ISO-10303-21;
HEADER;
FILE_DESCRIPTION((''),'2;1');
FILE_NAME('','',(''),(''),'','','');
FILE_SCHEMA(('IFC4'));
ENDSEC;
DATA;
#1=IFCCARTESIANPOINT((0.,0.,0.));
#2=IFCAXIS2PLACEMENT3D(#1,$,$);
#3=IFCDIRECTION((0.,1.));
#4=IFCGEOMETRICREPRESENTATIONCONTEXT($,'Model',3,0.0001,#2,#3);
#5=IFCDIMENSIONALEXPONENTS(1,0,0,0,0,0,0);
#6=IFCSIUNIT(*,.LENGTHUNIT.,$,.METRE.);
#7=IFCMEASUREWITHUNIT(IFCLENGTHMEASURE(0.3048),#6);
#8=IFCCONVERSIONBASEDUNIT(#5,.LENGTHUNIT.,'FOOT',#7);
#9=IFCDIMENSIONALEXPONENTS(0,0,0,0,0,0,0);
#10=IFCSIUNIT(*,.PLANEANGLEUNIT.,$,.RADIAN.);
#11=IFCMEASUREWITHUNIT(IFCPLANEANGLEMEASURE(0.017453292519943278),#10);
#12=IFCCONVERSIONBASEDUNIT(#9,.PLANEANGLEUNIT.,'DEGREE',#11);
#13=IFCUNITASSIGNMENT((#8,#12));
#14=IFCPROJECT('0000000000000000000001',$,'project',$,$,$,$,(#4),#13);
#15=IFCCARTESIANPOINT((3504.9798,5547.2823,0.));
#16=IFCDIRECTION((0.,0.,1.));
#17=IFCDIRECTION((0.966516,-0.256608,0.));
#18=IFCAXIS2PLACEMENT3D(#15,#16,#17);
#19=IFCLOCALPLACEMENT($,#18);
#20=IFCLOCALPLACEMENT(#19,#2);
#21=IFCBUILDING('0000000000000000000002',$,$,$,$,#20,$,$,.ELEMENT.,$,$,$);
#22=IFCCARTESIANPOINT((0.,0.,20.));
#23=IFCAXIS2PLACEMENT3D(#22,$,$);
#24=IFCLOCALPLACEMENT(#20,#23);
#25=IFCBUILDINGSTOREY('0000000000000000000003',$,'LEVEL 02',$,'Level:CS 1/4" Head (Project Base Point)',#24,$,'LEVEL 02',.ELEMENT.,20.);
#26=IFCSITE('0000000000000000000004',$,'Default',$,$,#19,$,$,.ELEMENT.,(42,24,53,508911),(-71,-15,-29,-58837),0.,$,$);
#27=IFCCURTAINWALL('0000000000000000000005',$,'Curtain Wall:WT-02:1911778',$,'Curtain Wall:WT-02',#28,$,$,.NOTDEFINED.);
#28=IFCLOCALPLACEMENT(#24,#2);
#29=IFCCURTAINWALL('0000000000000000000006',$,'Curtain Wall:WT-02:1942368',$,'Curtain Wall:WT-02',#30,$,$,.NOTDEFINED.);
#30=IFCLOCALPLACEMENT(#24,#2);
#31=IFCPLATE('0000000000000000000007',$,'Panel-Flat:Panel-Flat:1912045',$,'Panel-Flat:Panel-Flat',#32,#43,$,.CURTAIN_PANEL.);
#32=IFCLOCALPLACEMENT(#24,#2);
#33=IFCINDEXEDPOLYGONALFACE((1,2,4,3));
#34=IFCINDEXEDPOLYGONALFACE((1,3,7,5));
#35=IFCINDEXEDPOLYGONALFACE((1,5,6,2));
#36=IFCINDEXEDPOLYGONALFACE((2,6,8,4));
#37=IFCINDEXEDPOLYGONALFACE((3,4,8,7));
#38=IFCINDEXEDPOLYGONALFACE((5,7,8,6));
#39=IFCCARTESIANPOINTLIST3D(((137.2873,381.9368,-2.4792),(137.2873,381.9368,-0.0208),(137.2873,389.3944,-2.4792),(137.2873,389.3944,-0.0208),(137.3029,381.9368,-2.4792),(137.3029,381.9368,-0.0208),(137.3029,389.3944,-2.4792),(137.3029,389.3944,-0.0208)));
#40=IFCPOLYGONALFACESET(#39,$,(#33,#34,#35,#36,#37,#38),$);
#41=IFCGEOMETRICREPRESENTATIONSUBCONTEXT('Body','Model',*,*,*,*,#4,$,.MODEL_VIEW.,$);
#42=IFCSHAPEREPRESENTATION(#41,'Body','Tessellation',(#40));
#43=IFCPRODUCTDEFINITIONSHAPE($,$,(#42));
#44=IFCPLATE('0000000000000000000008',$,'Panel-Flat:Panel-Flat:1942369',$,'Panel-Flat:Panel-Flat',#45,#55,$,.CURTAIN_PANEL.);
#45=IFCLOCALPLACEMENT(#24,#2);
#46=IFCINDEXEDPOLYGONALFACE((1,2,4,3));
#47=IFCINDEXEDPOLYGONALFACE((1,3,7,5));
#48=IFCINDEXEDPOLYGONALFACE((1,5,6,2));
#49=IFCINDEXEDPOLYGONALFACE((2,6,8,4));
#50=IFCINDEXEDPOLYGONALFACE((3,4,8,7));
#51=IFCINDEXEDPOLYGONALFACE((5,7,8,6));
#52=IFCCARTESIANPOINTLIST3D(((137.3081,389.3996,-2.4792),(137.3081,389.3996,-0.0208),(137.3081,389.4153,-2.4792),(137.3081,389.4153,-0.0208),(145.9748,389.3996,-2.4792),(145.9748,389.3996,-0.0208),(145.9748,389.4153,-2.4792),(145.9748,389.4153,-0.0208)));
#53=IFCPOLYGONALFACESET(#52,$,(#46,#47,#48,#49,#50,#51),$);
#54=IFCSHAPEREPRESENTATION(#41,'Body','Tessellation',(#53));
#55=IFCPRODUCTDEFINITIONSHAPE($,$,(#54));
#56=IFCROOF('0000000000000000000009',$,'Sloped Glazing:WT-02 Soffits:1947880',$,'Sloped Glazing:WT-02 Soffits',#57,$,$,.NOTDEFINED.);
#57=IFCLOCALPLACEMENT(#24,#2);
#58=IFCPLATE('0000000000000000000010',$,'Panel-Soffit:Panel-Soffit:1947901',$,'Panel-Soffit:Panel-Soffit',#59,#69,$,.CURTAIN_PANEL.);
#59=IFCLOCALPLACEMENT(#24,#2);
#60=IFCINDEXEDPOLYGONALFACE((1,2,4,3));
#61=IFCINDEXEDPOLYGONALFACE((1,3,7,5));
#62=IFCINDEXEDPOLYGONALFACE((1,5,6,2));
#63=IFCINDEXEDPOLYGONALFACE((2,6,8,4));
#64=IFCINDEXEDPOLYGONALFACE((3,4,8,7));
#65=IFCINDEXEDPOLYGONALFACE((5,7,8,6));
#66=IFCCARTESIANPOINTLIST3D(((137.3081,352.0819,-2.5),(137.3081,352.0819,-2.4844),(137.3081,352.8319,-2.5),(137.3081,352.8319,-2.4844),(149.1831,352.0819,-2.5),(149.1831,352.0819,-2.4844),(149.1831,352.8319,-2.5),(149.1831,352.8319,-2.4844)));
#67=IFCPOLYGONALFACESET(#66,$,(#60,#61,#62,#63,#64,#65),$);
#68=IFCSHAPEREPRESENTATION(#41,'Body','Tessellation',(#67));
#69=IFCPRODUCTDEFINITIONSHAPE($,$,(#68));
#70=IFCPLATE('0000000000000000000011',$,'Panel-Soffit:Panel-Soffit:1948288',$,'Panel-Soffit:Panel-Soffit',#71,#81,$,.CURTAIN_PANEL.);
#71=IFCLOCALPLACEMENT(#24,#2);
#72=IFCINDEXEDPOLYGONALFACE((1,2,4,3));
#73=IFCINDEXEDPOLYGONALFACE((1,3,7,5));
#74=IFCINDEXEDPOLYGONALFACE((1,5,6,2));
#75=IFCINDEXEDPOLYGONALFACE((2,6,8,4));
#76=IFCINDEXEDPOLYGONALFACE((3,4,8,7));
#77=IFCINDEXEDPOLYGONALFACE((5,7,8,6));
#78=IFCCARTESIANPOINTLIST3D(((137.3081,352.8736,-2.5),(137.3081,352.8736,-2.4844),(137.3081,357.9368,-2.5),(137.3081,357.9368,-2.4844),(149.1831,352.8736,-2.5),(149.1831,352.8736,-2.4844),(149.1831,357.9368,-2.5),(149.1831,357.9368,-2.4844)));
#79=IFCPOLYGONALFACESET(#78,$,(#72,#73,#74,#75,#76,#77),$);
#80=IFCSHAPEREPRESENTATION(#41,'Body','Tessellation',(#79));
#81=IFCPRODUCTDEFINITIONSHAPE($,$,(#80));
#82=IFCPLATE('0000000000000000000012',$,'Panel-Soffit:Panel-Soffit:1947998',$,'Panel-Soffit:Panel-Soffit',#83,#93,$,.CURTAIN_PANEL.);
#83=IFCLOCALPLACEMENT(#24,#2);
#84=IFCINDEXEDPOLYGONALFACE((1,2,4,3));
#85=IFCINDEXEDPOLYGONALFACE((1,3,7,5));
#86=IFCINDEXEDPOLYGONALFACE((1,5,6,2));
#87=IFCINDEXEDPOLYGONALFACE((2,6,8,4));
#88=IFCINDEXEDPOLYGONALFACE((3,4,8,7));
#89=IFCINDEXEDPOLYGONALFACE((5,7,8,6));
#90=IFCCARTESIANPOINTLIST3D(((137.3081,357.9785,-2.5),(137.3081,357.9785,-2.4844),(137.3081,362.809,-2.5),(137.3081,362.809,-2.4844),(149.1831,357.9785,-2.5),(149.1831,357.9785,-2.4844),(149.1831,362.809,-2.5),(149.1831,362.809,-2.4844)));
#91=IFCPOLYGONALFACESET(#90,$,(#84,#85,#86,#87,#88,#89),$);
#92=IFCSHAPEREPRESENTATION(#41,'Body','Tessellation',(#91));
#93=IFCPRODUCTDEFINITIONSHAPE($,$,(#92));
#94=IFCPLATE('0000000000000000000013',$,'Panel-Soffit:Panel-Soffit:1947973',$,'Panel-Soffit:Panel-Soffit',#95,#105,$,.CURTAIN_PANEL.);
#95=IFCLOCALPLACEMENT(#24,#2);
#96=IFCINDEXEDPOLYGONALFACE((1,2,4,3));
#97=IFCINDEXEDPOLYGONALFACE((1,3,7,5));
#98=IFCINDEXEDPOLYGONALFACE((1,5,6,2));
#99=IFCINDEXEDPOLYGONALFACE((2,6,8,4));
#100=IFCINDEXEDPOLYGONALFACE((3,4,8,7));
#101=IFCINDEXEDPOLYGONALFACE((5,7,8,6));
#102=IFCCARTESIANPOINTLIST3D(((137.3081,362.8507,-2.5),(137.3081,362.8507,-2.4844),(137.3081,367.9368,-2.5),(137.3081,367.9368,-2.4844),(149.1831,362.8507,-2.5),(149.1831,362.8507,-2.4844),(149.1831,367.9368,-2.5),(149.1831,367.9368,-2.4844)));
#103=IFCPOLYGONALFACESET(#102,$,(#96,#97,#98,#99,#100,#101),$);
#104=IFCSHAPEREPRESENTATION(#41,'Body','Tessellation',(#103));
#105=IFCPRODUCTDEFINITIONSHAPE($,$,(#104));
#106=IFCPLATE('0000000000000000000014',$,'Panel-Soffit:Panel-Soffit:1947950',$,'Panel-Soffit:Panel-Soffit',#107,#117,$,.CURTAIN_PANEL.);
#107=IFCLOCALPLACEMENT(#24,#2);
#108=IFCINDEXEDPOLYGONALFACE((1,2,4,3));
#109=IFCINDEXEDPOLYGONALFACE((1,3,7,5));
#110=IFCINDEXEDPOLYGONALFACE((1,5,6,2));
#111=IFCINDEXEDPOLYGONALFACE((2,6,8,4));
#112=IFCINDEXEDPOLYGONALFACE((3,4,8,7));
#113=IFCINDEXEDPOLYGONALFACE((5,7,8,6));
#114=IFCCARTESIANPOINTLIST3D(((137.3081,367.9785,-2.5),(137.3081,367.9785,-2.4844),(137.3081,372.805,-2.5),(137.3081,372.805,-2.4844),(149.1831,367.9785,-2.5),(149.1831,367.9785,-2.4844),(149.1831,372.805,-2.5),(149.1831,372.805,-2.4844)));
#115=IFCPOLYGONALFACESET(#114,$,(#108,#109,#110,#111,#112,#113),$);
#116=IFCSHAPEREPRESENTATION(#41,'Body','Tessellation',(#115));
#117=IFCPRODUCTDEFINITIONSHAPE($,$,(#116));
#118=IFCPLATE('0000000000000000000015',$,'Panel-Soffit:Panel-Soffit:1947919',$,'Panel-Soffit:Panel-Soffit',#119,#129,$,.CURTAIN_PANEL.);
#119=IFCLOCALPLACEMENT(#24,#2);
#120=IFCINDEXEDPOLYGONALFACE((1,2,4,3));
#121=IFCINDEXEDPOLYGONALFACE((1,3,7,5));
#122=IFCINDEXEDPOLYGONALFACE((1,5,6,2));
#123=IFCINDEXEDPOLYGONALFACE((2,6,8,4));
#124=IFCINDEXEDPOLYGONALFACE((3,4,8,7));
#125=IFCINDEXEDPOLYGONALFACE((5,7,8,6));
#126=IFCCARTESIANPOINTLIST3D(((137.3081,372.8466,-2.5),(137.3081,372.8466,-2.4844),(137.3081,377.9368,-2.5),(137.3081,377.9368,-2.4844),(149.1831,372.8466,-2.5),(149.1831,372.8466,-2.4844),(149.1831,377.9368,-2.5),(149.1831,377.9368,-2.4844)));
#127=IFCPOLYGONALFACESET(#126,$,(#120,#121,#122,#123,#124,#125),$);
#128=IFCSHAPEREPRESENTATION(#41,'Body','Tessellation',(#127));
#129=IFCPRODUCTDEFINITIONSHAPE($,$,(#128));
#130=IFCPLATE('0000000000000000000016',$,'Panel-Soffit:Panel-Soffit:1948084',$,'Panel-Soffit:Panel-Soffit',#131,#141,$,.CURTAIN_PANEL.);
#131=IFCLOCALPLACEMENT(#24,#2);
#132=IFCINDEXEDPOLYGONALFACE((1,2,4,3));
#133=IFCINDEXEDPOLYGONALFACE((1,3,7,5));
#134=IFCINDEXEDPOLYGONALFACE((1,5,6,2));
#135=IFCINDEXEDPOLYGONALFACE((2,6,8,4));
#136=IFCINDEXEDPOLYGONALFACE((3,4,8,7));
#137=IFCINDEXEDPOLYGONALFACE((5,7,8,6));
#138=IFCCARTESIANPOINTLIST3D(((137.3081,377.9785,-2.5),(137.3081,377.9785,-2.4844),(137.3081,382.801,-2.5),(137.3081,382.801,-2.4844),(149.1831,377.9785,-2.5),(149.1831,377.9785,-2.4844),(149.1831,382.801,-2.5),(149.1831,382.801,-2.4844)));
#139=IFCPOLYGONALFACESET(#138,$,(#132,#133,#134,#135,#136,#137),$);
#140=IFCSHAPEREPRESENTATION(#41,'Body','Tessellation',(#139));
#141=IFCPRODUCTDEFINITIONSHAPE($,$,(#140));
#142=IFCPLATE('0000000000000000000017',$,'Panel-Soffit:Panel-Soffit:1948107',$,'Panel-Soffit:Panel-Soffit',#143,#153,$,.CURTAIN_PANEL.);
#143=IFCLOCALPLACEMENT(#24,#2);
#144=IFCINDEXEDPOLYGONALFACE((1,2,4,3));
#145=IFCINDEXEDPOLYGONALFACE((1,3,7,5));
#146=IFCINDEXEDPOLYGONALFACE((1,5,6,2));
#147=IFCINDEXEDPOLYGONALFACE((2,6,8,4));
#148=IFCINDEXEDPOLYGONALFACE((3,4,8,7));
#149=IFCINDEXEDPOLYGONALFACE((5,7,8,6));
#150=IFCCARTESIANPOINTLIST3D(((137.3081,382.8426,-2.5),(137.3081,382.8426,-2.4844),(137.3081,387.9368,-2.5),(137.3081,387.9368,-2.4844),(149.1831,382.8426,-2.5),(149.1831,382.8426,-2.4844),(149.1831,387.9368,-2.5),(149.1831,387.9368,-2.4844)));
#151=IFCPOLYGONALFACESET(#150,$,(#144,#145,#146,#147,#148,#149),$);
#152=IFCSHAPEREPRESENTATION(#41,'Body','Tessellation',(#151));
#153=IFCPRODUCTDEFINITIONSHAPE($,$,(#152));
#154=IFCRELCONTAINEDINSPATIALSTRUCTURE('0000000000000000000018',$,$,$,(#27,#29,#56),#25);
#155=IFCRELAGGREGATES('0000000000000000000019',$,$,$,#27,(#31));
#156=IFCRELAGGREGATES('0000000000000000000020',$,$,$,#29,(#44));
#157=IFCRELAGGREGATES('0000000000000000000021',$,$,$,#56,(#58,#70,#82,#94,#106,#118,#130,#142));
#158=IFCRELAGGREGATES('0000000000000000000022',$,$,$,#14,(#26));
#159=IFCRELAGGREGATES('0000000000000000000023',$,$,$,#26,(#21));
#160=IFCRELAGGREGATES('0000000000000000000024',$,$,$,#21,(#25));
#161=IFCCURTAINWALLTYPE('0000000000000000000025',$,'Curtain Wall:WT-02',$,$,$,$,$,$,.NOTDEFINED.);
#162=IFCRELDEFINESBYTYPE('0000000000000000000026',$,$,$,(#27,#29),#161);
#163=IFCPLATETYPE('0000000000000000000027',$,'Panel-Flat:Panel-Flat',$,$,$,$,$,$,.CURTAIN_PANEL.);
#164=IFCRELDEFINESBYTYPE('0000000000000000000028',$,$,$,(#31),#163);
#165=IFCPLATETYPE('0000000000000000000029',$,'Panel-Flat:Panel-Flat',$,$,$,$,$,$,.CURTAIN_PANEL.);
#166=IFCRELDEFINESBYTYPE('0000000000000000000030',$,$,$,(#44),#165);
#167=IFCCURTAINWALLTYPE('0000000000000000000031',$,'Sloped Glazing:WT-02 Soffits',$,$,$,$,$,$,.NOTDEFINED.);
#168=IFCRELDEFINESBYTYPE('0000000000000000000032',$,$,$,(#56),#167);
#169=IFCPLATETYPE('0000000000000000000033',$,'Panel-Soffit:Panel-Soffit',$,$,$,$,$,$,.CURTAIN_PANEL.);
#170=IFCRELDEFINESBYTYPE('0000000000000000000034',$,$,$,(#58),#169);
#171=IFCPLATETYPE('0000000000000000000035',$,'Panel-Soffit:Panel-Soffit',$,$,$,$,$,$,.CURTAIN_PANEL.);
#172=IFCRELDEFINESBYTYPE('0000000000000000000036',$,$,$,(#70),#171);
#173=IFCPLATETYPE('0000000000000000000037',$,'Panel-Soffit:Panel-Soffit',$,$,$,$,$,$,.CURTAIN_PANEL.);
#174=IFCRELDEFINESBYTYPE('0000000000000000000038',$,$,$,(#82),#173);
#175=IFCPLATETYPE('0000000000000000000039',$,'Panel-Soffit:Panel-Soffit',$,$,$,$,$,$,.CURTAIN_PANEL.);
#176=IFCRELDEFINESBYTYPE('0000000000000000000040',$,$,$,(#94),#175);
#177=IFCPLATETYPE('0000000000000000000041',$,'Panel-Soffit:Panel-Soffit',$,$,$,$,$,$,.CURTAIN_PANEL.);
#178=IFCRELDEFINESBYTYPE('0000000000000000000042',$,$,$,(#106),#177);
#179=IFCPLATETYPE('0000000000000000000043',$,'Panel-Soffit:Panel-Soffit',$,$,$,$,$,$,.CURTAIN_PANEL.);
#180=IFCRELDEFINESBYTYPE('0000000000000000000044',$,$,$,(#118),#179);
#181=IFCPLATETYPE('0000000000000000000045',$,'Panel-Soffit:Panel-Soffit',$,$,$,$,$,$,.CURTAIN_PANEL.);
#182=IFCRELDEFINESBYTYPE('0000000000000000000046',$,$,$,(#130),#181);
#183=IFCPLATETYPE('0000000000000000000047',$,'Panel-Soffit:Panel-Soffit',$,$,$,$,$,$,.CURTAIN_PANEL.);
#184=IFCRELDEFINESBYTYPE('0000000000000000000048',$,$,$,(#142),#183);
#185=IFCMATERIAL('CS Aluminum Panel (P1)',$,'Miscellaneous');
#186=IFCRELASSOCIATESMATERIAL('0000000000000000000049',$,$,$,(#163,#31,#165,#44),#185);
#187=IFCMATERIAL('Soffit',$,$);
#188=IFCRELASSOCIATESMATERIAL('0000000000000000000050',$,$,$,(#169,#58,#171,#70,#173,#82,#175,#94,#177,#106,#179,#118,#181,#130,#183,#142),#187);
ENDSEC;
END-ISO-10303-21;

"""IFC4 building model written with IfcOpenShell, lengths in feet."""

from ifc_helpers import new_model, entity, si_unit, converted_unit, direction, frame, origin, place, context, subcontext, project, spatial, indexed_curve, outline, extrude, source, transform, mapped, material, type_object, type_shapes, element, aggregate, save


model = new_model("IFC4")

# Units and contexts
model_context = context("Model", 3, precision=0.0001, world=origin(), true_north=direction((0.0, 1.0)))
body_context = subcontext(model_context, "Body", "Model", "MODEL_VIEW")
ifc_project = project(units=[converted_unit("LENGTHUNIT", "FOOT", entity("IfcLengthMeasure", 0.3048), si_unit("LENGTHUNIT", "METRE"), dimensions=[1, 0, 0, 0, 0, 0, 0]), converted_unit("PLANEANGLEUNIT", "DEGREE", entity("IfcPlaneAngleMeasure", 0.017453292519943278), si_unit("PLANEANGLEUNIT", "RADIAN"), dimensions=[0, 0, 0, 0, 0, 0, 0])], contexts=[model_context])

# Site, building, storey
site_placement = place(None, frame((3504.9798, 5547.2823, 0.0), z_axis=(0.0, 0.0, 1.0), x_axis=(0.966516, -0.256608, 0.0)))
site = spatial("IfcSite", under=ifc_project, at=site_placement, Name="Default", CompositionType="ELEMENT", RefLatitude=(42, 24, 53, 508911), RefLongitude=(-71, -15, -29, -58837), RefElevation=0.0)
building_placement = place(site_placement, origin())
building = spatial("IfcBuilding", under=site, at=building_placement, CompositionType="ELEMENT")
storey_placement = place(building_placement, frame((0.0, 0.0, 20.0)))
storey = spatial("IfcBuildingStorey", under=building, at=storey_placement, Name="LEVEL 02", ObjectType="Level:CS 1/4\" Head (Project Base Point)", LongName="LEVEL 02", CompositionType="ELEMENT", Elevation=20.0)

# Curtain walls
curtain_wall_type_1 = type_object("IfcCurtainWallType", Name="Curtain Wall:WT-02", PredefinedType="NOTDEFINED")
curtain_wall_1_placement = place(storey_placement, frame((0.0, 0.0, -20.0)))
curtain_wall_1 = element("IfcCurtainWall", 1, at=curtain_wall_1_placement, inside=storey, type_object=curtain_wall_type_1, Name="Curtain Wall:WT-02:1911778", ObjectType="Curtain Wall:WT-02", PredefinedType="NOTDEFINED")
ifc_material_1 = material(Name="CS Aluminum Panel (P1)", Category="Miscellaneous")
curtain_wall_2_placement = place(storey_placement, frame((0.0, 0.0, -20.0)))
curtain_wall_2 = element("IfcCurtainWall", 2, at=curtain_wall_2_placement, inside=storey, type_object=curtain_wall_type_1, Name="Curtain Wall:WT-02:1942368", ObjectType="Curtain Wall:WT-02", PredefinedType="NOTDEFINED")

# Plates
plate_type_1 = type_object("IfcPlateType", Name="Panel-Flat:Panel-Flat", PredefinedType="CURTAIN_PANEL", material=ifc_material_1)
shared_shape_1 = source(origin(), body_context, "Body", "SweptSolid", [
    extrude(outline(indexed_curve([(-0.0078, -3.7288), (0.0078, -3.7288), (0.0078, 3.7288), (-0.0078, 3.7288), (-0.0078, -3.7288)], self_intersect=False)), frame((0.0, -0.0078, 0.0208), z_axis=(0.0, 0.0, 1.0), x_axis=(0.0, -1.0, 0.0)), (0.0, 0.0, 1.0), 2.4583),
])
type_shapes(plate_type_1, [shared_shape_1])
plate_1_placement = place(curtain_wall_1_placement, frame((137.2873, 385.6656, 17.5), z_axis=(0.0, 0.0, 1.0), x_axis=(0.0, 1.0, 0.0)))
plate_1 = element("IfcPlate", 3, at=plate_1_placement, type_object=plate_type_1, material=ifc_material_1, Name="Panel-Flat:Panel-Flat:1912045", ObjectType="Panel-Flat:Panel-Flat", PredefinedType="CURTAIN_PANEL", context=body_context, shape_type="MappedRepresentation", body=[
    mapped(shared_shape_1, transform((0.0, 0.0, 0.0), scale=1.0)),
])
aggregate(curtain_wall_1, [plate_1])
plate_type_2 = type_object("IfcPlateType", Name="Panel-Flat:Panel-Flat", PredefinedType="CURTAIN_PANEL", material=ifc_material_1)
shared_shape_2 = source(origin(), body_context, "Body", "SweptSolid", [
    extrude(outline(indexed_curve([(-0.0078, -4.3333), (0.0078, -4.3333), (0.0078, 4.3333), (-0.0078, 4.3333), (-0.0078, -4.3333)], self_intersect=False)), frame((0.0, -0.0078, 0.0208), z_axis=(0.0, 0.0, 1.0), x_axis=(0.0, -1.0, 0.0)), (0.0, 0.0, 1.0), 2.4583),
])
type_shapes(plate_type_2, [shared_shape_2])
plate_2_placement = place(curtain_wall_2_placement, frame((141.6414, 389.4153, 17.5)))
plate_2 = element("IfcPlate", 4, at=plate_2_placement, type_object=plate_type_2, material=ifc_material_1, Name="Panel-Flat:Panel-Flat:1942369", ObjectType="Panel-Flat:Panel-Flat", PredefinedType="CURTAIN_PANEL", context=body_context, shape_type="MappedRepresentation", body=[
    mapped(shared_shape_2, transform((0.0, 0.0, 0.0), scale=1.0)),
])
aggregate(curtain_wall_2, [plate_2])

# Roof, plates
curtain_wall_type_2 = type_object("IfcCurtainWallType", Name="Sloped Glazing:WT-02 Soffits", PredefinedType="NOTDEFINED")
roof_1_placement = place(storey_placement, frame((0.0, 0.0, -20.0)))
roof_1 = element("IfcRoof", 5, at=roof_1_placement, inside=storey, type_object=curtain_wall_type_2, Name="Sloped Glazing:WT-02 Soffits:1947880", ObjectType="Sloped Glazing:WT-02 Soffits", PredefinedType="NOTDEFINED")
ifc_material_2 = material(Name="Soffit")
plate_type_3 = type_object("IfcPlateType", Name="Panel-Soffit:Panel-Soffit", PredefinedType="CURTAIN_PANEL", material=ifc_material_2)
shared_shape_3 = source(origin(), body_context, "Body", "SweptSolid", [
    extrude(outline(indexed_curve([(-0.0078, -5.9375), (0.0078, -5.9375), (0.0078, 5.9375), (-0.0078, 5.9375), (-0.0078, -5.9375)], self_intersect=False)), frame((0.0, -0.0078, 0.0208), z_axis=(0.0, 0.0, 1.0), x_axis=(0.0, -1.0, 0.0)), (0.0, 0.0, 1.0), 0.75),
])
type_shapes(plate_type_3, [shared_shape_3])
plate_3_placement = place(roof_1_placement, frame((143.2456, 352.0611, 17.5), z_axis=(0.0, 1.0, 0.0), x_axis=(1.0, 0.0, 0.0)))
plate_3 = element("IfcPlate", 6, at=plate_3_placement, type_object=plate_type_3, material=ifc_material_2, Name="Panel-Soffit:Panel-Soffit:1947901", ObjectType="Panel-Soffit:Panel-Soffit", PredefinedType="CURTAIN_PANEL", context=body_context, shape_type="MappedRepresentation", body=[
    mapped(shared_shape_3, transform((0.0, 0.0, 0.0), scale=1.0)),
])
plate_type_4 = type_object("IfcPlateType", Name="Panel-Soffit:Panel-Soffit", PredefinedType="CURTAIN_PANEL", material=ifc_material_2)
shared_shape_4 = source(origin(), body_context, "Body", "SweptSolid", [
    extrude(outline(indexed_curve([(-0.0078, -5.9375), (0.0078, -5.9375), (0.0078, 5.9375), (-0.0078, 5.9375), (-0.0078, -5.9375)], self_intersect=False)), frame((0.0, -0.0078, 0.0208), z_axis=(0.0, 0.0, 1.0), x_axis=(0.0, -1.0, 0.0)), (0.0, 0.0, 1.0), 5.0633),
])
type_shapes(plate_type_4, [shared_shape_4])
plate_4_placement = place(roof_1_placement, frame((143.2456, 352.8528, 17.5), z_axis=(0.0, 1.0, 0.0), x_axis=(1.0, 0.0, 0.0)))
plate_4 = element("IfcPlate", 7, at=plate_4_placement, type_object=plate_type_4, material=ifc_material_2, Name="Panel-Soffit:Panel-Soffit:1948288", ObjectType="Panel-Soffit:Panel-Soffit", PredefinedType="CURTAIN_PANEL", context=body_context, shape_type="MappedRepresentation", body=[
    mapped(shared_shape_4, transform((0.0, 0.0, 0.0), scale=1.0)),
])
plate_type_5 = type_object("IfcPlateType", Name="Panel-Soffit:Panel-Soffit", PredefinedType="CURTAIN_PANEL", material=ifc_material_2)
shared_shape_5 = source(origin(), body_context, "Body", "SweptSolid", [
    extrude(outline(indexed_curve([(-0.0078, -5.9375), (0.0078, -5.9375), (0.0078, 5.9375), (-0.0078, 5.9375), (-0.0078, -5.9375)], self_intersect=False)), frame((0.0, -0.0078, 0.0208), z_axis=(0.0, 0.0, 1.0), x_axis=(0.0, -1.0, 0.0)), (0.0, 0.0, 1.0), 4.8305),
])
type_shapes(plate_type_5, [shared_shape_5])
plate_5_placement = place(roof_1_placement, frame((143.2456, 357.9577, 17.5), z_axis=(0.0, 1.0, 0.0), x_axis=(1.0, 0.0, 0.0)))
plate_5 = element("IfcPlate", 8, at=plate_5_placement, type_object=plate_type_5, material=ifc_material_2, Name="Panel-Soffit:Panel-Soffit:1947998", ObjectType="Panel-Soffit:Panel-Soffit", PredefinedType="CURTAIN_PANEL", context=body_context, shape_type="MappedRepresentation", body=[
    mapped(shared_shape_5, transform((0.0, 0.0, 0.0), scale=1.0)),
])
plate_type_6 = type_object("IfcPlateType", Name="Panel-Soffit:Panel-Soffit", PredefinedType="CURTAIN_PANEL", material=ifc_material_2)
shared_shape_6 = source(origin(), body_context, "Body", "SweptSolid", [
    extrude(outline(indexed_curve([(-0.0078, -5.9375), (0.0078, -5.9375), (0.0078, 5.9375), (-0.0078, 5.9375), (-0.0078, -5.9375)], self_intersect=False)), frame((0.0, -0.0078, 0.0208), z_axis=(0.0, 0.0, 1.0), x_axis=(0.0, -1.0, 0.0)), (0.0, 0.0, 1.0), 5.0862),
])
type_shapes(plate_type_6, [shared_shape_6])
plate_6_placement = place(roof_1_placement, frame((143.2456, 362.8298, 17.5), z_axis=(0.0, 1.0, 0.0), x_axis=(1.0, 0.0, 0.0)))
plate_6 = element("IfcPlate", 9, at=plate_6_placement, type_object=plate_type_6, material=ifc_material_2, Name="Panel-Soffit:Panel-Soffit:1947973", ObjectType="Panel-Soffit:Panel-Soffit", PredefinedType="CURTAIN_PANEL", context=body_context, shape_type="MappedRepresentation", body=[
    mapped(shared_shape_6, transform((0.0, 0.0, 0.0), scale=1.0)),
])
plate_type_7 = type_object("IfcPlateType", Name="Panel-Soffit:Panel-Soffit", PredefinedType="CURTAIN_PANEL", material=ifc_material_2)
shared_shape_7 = source(origin(), body_context, "Body", "SweptSolid", [
    extrude(outline(indexed_curve([(-0.0078, -5.9375), (0.0078, -5.9375), (0.0078, 5.9375), (-0.0078, 5.9375), (-0.0078, -5.9375)], self_intersect=False)), frame((0.0, -0.0078, 0.0208), z_axis=(0.0, 0.0, 1.0), x_axis=(0.0, -1.0, 0.0)), (0.0, 0.0, 1.0), 4.8265),
])
type_shapes(plate_type_7, [shared_shape_7])
plate_7_placement = place(roof_1_placement, frame((143.2456, 367.9577, 17.5), z_axis=(0.0, 1.0, 0.0), x_axis=(1.0, 0.0, 0.0)))
plate_7 = element("IfcPlate", 10, at=plate_7_placement, type_object=plate_type_7, material=ifc_material_2, Name="Panel-Soffit:Panel-Soffit:1947950", ObjectType="Panel-Soffit:Panel-Soffit", PredefinedType="CURTAIN_PANEL", context=body_context, shape_type="MappedRepresentation", body=[
    mapped(shared_shape_7, transform((0.0, 0.0, 0.0), scale=1.0)),
])
plate_type_8 = type_object("IfcPlateType", Name="Panel-Soffit:Panel-Soffit", PredefinedType="CURTAIN_PANEL", material=ifc_material_2)
shared_shape_8 = source(origin(), body_context, "Body", "SweptSolid", [
    extrude(outline(indexed_curve([(-0.0078, -5.9375), (0.0078, -5.9375), (0.0078, 5.9375), (-0.0078, 5.9375), (-0.0078, -5.9375)], self_intersect=False)), frame((0.0, -0.0078, 0.0208), z_axis=(0.0, 0.0, 1.0), x_axis=(0.0, -1.0, 0.0)), (0.0, 0.0, 1.0), 5.0902),
])
type_shapes(plate_type_8, [shared_shape_8])
plate_8_placement = place(roof_1_placement, frame((143.2456, 372.8258, 17.5), z_axis=(0.0, 1.0, 0.0), x_axis=(1.0, 0.0, 0.0)))
plate_8 = element("IfcPlate", 11, at=plate_8_placement, type_object=plate_type_8, material=ifc_material_2, Name="Panel-Soffit:Panel-Soffit:1947919", ObjectType="Panel-Soffit:Panel-Soffit", PredefinedType="CURTAIN_PANEL", context=body_context, shape_type="MappedRepresentation", body=[
    mapped(shared_shape_8, transform((0.0, 0.0, 0.0), scale=1.0)),
])
plate_type_9 = type_object("IfcPlateType", Name="Panel-Soffit:Panel-Soffit", PredefinedType="CURTAIN_PANEL", material=ifc_material_2)
shared_shape_9 = source(origin(), body_context, "Body", "SweptSolid", [
    extrude(outline(indexed_curve([(-0.0078, -5.9375), (0.0078, -5.9375), (0.0078, 5.9375), (-0.0078, 5.9375), (-0.0078, -5.9375)], self_intersect=False)), frame((0.0, -0.0078, 0.0208), z_axis=(0.0, 0.0, 1.0), x_axis=(0.0, -1.0, 0.0)), (0.0, 0.0, 1.0), 4.8224),
])
type_shapes(plate_type_9, [shared_shape_9])
plate_9_placement = place(roof_1_placement, frame((143.2456, 377.9577, 17.5), z_axis=(0.0, 1.0, 0.0), x_axis=(1.0, 0.0, 0.0)))
plate_9 = element("IfcPlate", 12, at=plate_9_placement, type_object=plate_type_9, material=ifc_material_2, Name="Panel-Soffit:Panel-Soffit:1948084", ObjectType="Panel-Soffit:Panel-Soffit", PredefinedType="CURTAIN_PANEL", context=body_context, shape_type="MappedRepresentation", body=[
    mapped(shared_shape_9, transform((0.0, 0.0, 0.0), scale=1.0)),
])
plate_type_10 = type_object("IfcPlateType", Name="Panel-Soffit:Panel-Soffit", PredefinedType="CURTAIN_PANEL", material=ifc_material_2)
shared_shape_10 = source(origin(), body_context, "Body", "SweptSolid", [
    extrude(outline(indexed_curve([(-0.0078, -5.9375), (0.0078, -5.9375), (0.0078, 5.9375), (-0.0078, 5.9375), (-0.0078, -5.9375)], self_intersect=False)), frame((0.0, -0.0078, 0.0208), z_axis=(0.0, 0.0, 1.0), x_axis=(0.0, -1.0, 0.0)), (0.0, 0.0, 1.0), 5.0942),
])
type_shapes(plate_type_10, [shared_shape_10])
plate_10_placement = place(roof_1_placement, frame((143.2456, 382.8218, 17.5), z_axis=(0.0, 1.0, 0.0), x_axis=(1.0, 0.0, 0.0)))
plate_10 = element("IfcPlate", 13, at=plate_10_placement, type_object=plate_type_10, material=ifc_material_2, Name="Panel-Soffit:Panel-Soffit:1948107", ObjectType="Panel-Soffit:Panel-Soffit", PredefinedType="CURTAIN_PANEL", context=body_context, shape_type="MappedRepresentation", body=[
    mapped(shared_shape_10, transform((0.0, 0.0, 0.0), scale=1.0)),
])
aggregate(roof_1, [plate_3, plate_4, plate_5, plate_6, plate_7, plate_8, plate_9, plate_10])

save(model, "model.ifc")
